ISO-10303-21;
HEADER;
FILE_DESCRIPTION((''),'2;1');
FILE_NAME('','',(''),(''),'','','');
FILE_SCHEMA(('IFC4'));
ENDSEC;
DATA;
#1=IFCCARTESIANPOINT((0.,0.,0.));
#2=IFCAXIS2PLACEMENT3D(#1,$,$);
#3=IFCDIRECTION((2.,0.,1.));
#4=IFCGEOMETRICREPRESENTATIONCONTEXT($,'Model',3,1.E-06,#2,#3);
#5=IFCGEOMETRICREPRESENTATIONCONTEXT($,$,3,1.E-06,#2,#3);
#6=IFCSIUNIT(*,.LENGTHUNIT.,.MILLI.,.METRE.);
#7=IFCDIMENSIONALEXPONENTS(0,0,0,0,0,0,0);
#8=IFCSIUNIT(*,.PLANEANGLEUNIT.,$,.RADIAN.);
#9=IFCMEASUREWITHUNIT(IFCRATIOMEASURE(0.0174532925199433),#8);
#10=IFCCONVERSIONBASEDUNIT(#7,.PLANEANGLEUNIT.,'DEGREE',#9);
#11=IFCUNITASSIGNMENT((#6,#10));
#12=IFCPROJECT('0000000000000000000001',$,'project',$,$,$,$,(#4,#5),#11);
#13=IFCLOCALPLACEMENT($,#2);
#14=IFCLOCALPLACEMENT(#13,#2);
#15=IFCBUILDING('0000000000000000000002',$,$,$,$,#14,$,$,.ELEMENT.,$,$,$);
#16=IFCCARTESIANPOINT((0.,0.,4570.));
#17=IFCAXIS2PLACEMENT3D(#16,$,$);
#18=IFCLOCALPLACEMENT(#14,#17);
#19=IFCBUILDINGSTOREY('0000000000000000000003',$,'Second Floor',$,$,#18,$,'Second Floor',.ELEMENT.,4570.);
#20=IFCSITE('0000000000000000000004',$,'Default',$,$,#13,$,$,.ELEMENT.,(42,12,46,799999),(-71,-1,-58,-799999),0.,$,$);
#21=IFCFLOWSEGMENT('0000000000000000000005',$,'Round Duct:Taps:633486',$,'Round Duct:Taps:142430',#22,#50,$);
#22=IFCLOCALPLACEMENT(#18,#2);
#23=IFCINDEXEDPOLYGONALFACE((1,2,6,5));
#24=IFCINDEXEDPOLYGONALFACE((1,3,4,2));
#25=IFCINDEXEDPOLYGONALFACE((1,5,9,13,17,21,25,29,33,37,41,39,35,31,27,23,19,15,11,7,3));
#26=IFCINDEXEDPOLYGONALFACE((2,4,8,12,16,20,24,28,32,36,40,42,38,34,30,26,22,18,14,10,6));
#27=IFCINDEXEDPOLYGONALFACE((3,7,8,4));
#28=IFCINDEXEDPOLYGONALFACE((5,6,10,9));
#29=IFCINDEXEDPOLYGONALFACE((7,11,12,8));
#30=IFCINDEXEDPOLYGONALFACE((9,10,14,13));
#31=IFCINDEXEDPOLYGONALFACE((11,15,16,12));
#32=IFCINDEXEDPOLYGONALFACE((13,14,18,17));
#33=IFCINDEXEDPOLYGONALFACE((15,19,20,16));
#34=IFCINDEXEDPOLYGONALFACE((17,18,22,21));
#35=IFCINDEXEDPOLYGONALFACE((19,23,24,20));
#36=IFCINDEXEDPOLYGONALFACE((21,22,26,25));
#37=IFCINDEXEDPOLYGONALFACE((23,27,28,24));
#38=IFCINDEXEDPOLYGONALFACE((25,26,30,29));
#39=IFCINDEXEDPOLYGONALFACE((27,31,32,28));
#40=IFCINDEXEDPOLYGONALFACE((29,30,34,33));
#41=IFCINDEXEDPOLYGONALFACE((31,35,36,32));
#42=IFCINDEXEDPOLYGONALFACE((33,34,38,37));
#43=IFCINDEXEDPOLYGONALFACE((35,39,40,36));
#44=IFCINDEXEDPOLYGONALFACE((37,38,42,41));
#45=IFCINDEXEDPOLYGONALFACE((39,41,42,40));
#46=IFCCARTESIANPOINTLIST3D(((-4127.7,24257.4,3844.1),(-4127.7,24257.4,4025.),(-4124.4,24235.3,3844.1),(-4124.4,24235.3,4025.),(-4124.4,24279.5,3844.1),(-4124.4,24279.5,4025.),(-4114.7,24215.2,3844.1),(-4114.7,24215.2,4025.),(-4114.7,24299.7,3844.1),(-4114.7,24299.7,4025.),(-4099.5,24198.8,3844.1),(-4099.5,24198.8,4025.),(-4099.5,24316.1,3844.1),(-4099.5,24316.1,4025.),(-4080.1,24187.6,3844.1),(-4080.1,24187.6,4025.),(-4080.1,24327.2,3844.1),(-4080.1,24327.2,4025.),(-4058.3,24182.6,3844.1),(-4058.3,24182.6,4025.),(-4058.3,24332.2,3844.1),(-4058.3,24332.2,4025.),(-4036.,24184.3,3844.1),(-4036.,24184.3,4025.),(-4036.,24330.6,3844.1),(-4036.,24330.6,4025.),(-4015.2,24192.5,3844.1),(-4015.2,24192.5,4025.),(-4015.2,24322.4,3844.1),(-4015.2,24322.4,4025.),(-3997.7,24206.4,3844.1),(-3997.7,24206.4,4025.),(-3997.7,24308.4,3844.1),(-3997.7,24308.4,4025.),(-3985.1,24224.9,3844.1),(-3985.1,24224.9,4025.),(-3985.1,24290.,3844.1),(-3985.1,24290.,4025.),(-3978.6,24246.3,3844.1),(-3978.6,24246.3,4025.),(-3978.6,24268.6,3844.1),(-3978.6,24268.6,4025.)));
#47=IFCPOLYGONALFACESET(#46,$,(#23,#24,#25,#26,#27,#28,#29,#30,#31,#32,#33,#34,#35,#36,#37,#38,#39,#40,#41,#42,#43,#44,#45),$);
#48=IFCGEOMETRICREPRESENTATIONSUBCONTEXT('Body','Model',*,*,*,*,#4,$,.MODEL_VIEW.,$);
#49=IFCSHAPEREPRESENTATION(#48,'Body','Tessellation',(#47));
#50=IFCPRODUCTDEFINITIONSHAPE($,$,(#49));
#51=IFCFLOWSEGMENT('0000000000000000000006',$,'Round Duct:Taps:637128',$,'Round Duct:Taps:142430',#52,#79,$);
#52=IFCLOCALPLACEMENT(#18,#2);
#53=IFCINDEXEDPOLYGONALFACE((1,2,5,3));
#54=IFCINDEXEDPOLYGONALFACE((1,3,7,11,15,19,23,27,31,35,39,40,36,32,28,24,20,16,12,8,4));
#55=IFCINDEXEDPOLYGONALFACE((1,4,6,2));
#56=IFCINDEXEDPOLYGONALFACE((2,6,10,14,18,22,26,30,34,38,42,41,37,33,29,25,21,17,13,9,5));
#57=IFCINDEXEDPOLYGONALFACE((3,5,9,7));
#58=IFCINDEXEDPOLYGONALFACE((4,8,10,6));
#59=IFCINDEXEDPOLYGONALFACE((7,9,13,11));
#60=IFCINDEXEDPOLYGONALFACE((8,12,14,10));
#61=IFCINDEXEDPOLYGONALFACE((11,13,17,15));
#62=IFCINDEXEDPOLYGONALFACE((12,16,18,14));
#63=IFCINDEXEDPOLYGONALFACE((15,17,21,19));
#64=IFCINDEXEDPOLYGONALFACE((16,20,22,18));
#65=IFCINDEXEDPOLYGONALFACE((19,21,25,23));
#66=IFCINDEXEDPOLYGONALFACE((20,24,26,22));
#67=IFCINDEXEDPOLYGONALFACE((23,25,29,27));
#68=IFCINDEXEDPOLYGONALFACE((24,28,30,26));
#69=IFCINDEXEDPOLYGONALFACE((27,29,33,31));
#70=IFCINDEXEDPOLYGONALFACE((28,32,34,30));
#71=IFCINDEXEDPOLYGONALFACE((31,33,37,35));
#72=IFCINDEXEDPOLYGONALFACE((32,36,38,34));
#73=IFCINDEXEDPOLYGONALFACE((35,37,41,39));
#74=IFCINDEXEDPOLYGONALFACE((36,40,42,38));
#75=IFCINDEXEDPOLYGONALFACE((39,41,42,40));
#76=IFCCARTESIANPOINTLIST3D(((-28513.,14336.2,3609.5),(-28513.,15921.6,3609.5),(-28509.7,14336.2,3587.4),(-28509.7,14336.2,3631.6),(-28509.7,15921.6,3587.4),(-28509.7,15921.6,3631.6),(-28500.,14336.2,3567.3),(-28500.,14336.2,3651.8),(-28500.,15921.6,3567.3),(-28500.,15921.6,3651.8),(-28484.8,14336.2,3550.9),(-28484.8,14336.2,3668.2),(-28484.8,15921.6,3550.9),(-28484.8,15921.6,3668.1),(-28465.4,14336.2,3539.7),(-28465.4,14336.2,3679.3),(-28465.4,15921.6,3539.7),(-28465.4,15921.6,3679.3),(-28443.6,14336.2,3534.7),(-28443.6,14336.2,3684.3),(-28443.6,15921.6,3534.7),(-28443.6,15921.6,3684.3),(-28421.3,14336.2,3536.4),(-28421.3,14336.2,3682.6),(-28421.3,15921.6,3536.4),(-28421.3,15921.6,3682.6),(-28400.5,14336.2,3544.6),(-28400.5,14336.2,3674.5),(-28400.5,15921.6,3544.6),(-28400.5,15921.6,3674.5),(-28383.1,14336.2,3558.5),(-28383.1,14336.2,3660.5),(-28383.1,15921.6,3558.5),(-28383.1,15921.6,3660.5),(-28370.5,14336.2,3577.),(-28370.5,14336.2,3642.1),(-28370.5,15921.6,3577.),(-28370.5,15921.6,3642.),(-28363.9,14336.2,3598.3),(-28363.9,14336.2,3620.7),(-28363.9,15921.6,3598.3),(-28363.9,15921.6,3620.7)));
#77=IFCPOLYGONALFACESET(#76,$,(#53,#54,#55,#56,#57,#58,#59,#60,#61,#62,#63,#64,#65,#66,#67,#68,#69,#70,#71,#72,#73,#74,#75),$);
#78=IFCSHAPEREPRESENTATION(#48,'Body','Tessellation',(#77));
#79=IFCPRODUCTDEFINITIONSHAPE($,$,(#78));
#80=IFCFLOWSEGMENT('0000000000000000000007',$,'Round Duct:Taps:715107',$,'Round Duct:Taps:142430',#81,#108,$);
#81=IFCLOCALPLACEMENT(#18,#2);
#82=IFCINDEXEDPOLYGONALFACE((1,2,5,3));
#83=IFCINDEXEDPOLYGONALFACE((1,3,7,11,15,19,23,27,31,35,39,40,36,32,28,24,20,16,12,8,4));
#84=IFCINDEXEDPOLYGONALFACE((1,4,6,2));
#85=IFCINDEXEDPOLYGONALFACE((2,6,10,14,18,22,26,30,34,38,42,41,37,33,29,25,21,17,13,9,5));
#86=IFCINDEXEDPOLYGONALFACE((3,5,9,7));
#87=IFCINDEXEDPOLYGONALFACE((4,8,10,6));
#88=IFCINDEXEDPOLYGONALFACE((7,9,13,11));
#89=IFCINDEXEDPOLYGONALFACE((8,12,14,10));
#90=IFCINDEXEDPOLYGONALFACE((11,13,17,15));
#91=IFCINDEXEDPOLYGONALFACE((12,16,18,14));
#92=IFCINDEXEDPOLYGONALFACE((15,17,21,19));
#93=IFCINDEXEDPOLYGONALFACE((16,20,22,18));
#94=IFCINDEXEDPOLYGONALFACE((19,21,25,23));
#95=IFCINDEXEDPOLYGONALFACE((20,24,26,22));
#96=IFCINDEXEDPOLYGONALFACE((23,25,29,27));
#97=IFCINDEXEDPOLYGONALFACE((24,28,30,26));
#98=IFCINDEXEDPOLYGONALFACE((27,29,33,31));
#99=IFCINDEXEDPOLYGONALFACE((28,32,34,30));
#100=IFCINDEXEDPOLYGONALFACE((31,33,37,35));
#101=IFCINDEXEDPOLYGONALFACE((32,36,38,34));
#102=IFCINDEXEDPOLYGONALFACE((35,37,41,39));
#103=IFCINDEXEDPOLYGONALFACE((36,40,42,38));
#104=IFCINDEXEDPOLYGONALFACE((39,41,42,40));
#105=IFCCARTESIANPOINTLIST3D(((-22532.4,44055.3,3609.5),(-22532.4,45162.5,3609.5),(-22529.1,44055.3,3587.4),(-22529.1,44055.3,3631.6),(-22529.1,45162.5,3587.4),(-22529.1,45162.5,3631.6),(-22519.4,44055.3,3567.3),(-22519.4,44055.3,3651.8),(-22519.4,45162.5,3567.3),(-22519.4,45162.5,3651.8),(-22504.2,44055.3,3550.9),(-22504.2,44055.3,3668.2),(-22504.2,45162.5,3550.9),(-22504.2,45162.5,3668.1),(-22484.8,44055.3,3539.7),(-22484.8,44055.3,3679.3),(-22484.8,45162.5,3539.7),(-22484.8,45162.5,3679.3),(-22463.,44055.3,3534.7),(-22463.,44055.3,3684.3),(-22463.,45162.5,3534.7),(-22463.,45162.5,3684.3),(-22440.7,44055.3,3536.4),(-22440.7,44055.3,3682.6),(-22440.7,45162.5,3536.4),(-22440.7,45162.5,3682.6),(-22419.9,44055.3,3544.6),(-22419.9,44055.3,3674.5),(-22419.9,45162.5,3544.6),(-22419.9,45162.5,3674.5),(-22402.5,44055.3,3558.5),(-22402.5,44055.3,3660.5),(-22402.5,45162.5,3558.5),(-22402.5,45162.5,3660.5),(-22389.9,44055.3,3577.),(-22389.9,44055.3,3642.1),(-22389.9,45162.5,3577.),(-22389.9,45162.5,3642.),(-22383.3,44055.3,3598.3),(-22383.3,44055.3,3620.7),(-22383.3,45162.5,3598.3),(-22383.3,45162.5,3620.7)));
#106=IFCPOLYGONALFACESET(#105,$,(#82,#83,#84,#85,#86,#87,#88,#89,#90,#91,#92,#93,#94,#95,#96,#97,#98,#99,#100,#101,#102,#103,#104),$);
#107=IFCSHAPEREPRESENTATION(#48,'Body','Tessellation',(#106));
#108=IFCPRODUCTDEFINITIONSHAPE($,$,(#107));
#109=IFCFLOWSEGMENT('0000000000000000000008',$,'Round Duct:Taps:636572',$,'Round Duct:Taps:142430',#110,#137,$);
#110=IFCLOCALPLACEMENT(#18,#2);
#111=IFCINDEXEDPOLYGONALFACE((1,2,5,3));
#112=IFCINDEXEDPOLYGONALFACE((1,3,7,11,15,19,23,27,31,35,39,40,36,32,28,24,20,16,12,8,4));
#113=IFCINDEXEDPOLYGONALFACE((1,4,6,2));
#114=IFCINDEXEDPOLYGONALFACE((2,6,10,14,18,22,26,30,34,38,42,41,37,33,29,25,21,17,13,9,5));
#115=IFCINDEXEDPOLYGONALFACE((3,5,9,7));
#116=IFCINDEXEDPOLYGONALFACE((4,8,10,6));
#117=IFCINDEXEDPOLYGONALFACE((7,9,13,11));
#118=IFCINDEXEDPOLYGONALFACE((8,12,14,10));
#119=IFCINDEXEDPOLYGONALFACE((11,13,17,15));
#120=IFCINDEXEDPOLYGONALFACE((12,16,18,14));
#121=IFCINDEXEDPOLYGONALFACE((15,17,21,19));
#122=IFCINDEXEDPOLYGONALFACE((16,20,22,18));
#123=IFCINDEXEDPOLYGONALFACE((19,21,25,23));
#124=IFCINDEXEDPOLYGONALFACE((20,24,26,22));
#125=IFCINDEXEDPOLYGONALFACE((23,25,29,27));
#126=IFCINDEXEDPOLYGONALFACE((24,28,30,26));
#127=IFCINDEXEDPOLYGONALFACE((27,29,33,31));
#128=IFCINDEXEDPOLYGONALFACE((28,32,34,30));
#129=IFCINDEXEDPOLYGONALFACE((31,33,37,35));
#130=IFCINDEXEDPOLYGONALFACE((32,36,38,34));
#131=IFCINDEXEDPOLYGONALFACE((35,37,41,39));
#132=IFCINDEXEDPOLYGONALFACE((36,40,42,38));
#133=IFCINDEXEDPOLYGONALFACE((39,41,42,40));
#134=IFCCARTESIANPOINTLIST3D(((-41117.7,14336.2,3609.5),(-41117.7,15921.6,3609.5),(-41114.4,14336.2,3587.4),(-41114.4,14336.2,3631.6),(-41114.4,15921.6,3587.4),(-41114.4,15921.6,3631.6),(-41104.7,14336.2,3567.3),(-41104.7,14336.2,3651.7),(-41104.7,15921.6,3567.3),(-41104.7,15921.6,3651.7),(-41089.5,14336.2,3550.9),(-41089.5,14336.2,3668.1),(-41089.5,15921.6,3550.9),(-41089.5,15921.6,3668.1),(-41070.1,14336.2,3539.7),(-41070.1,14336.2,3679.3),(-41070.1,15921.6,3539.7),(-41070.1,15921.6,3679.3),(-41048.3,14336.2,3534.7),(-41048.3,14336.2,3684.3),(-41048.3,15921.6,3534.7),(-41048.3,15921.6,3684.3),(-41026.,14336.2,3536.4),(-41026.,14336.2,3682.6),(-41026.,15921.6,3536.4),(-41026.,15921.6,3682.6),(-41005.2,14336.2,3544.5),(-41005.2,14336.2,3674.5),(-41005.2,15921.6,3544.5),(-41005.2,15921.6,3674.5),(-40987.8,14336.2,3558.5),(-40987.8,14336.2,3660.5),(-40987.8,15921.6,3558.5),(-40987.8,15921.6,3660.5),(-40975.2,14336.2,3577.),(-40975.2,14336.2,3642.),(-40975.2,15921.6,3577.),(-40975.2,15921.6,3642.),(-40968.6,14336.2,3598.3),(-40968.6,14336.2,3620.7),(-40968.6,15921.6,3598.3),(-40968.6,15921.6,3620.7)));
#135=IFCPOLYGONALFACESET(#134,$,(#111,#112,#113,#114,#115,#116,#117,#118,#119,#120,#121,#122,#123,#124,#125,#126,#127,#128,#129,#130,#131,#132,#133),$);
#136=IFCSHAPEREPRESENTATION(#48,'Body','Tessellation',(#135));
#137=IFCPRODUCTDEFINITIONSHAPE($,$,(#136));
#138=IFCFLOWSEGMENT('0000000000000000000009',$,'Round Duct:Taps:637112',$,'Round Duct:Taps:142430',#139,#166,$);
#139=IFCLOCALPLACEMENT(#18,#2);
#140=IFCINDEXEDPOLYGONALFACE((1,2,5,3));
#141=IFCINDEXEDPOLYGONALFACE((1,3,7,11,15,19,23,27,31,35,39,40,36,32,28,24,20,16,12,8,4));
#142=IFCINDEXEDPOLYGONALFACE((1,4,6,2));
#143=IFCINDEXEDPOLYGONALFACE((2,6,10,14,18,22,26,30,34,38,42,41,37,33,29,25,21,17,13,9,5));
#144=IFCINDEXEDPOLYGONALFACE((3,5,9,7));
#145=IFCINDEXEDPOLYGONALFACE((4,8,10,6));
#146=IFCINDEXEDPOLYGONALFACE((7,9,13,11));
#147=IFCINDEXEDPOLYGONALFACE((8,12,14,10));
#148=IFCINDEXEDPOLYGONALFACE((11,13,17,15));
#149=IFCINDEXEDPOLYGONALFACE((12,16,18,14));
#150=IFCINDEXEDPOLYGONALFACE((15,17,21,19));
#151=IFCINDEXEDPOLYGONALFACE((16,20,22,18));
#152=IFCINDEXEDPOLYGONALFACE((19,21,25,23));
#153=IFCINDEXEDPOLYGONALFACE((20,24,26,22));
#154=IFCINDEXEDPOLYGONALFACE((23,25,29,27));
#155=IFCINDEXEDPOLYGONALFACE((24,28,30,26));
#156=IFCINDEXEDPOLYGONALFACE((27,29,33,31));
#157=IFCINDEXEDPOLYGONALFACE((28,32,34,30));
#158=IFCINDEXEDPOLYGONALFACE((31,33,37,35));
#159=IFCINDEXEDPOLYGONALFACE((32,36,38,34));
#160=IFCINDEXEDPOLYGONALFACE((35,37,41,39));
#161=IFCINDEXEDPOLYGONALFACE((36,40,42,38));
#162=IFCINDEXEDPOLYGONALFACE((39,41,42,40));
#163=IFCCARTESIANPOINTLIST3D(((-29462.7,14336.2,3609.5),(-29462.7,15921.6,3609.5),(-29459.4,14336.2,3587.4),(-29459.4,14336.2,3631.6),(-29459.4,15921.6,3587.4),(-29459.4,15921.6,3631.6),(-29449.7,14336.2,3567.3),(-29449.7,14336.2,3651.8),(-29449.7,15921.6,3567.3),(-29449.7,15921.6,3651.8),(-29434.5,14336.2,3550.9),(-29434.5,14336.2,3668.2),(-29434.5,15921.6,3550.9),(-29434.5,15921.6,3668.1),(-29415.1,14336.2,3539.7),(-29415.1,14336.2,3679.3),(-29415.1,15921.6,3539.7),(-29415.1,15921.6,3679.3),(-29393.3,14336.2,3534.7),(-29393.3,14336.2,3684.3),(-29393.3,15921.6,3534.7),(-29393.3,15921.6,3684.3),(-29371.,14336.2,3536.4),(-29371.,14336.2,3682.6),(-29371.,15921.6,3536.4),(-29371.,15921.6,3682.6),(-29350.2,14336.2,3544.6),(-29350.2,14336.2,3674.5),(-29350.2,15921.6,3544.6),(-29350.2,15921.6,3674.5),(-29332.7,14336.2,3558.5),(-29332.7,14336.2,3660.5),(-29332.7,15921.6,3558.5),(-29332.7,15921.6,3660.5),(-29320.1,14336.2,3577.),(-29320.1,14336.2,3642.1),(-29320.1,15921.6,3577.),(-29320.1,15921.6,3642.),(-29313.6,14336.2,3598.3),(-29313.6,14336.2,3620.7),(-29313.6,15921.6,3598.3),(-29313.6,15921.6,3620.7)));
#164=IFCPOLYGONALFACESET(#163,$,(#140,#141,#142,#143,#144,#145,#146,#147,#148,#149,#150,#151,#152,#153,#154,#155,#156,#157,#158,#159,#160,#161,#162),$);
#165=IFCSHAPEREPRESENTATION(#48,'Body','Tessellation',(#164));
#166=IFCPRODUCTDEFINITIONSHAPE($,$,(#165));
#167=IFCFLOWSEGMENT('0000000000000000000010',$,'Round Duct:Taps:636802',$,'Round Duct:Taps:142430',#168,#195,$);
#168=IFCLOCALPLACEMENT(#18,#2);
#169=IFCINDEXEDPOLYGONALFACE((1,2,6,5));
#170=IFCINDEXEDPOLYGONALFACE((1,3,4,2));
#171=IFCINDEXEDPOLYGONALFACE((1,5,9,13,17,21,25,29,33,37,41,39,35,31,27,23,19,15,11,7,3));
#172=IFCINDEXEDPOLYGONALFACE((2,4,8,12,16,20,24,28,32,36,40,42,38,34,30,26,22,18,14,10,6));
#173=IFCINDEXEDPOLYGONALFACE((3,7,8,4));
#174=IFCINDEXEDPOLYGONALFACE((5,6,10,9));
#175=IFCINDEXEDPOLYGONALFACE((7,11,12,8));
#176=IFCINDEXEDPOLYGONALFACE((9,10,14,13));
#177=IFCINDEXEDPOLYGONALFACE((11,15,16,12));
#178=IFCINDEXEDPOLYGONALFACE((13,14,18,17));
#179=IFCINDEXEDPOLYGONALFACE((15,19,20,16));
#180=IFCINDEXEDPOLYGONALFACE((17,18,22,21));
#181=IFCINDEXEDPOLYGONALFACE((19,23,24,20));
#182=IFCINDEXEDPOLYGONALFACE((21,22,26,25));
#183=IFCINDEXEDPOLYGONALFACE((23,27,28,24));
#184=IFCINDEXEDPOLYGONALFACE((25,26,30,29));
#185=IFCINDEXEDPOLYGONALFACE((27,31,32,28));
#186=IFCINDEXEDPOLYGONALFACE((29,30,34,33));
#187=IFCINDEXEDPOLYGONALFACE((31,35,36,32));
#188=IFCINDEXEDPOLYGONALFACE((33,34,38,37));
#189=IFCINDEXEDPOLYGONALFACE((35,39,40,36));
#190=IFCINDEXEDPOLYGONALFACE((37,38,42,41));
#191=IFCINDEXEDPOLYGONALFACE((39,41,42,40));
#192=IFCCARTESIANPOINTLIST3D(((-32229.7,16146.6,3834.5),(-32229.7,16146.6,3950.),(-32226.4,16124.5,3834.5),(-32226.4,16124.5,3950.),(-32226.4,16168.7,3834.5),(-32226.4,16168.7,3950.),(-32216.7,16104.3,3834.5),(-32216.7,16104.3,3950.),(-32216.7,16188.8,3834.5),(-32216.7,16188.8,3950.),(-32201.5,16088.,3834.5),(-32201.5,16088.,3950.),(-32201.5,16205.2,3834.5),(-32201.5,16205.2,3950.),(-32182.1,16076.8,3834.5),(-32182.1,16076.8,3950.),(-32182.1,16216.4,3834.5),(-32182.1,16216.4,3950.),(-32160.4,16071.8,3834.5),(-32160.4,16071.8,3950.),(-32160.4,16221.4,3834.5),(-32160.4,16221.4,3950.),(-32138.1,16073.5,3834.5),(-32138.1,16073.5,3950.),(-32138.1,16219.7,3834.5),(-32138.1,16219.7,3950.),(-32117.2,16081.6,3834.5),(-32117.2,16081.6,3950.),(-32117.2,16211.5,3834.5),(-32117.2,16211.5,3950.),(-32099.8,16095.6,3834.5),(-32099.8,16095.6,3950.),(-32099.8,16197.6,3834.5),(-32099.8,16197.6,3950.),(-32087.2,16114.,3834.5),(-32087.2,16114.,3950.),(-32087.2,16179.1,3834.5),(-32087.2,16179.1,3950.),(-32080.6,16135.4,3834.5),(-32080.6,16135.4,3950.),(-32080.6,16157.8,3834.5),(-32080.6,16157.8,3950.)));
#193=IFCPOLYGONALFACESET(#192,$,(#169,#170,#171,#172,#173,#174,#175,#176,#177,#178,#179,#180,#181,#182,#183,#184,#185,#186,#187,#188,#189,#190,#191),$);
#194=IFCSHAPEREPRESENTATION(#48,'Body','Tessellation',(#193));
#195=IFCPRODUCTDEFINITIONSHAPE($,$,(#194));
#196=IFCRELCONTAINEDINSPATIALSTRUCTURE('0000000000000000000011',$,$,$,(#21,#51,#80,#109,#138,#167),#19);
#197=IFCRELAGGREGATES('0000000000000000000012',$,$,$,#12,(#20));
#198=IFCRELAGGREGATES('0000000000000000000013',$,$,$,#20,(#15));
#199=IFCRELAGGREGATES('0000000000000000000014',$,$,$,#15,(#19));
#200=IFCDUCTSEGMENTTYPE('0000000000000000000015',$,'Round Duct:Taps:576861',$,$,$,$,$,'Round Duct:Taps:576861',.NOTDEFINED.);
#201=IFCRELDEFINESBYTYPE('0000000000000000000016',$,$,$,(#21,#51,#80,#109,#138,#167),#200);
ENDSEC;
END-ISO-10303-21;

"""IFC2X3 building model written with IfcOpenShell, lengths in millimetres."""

from ifc_helpers import new_model, entity, si_unit, converted_unit, direction, frame, frame_2d, origin, origin_2d_with_axis, place, context, subcontext, project, spatial, circle, extrude, type_object, element, save


model = new_model("IFC2X3")

# Units and contexts
model_context = context("Model", 3, precision=1e-06, world=origin(), true_north=direction((2.0, 0.0, 1.0)))
context_of_model = context(None, 3, precision=1e-06, world=origin(), true_north=direction((2.0, 0.0, 1.0)))
body_context = subcontext(model_context, "Body", "Model", "MODEL_VIEW")
ifc_project = project(units=[si_unit("LENGTHUNIT", "METRE", prefix="MILLI"), converted_unit("PLANEANGLEUNIT", "DEGREE", entity("IfcRatioMeasure", 0.0174532925199433), si_unit("PLANEANGLEUNIT", "RADIAN"), dimensions=[0, 0, 0, 0, 0, 0, 0])], contexts=[model_context, context_of_model])

# Site, building, storey
site_placement = place(None, origin())
site = spatial("IfcSite", under=ifc_project, at=site_placement, Name="Default", CompositionType="ELEMENT", RefLatitude=(42, 12, 46, 799999), RefLongitude=(-71, -1, -58, -799999), RefElevation=0.0)
building_placement = place(site_placement, origin())
building = spatial("IfcBuilding", under=site, at=building_placement, CompositionType="ELEMENT")
storey_placement = place(building_placement, frame((0.0, 0.0, 4570.0)))
storey = spatial("IfcBuildingStorey", under=building, at=storey_placement, Name="Second Floor", LongName="Second Floor", CompositionType="ELEMENT", Elevation=4570.0)

# Flow segments
duct_segment_type_1 = type_object("IfcDuctSegmentType", Name="Round Duct:Taps:576861", ElementType="Round Duct:Taps:576861", PredefinedType="NOTDEFINED")
flow_segment_1_placement = place(storey_placement, origin())
element("IfcFlowSegment", 1, at=flow_segment_1_placement, inside=storey, type_object=duct_segment_type_1, Name="Round Duct:Taps:633486", ObjectType="Round Duct:Taps:142430", context=body_context, shape_type="SweptSolid", body=[
    extrude(circle(Radius=75.0, at=frame_2d((0.0, 0.0), x_axis=(1.0, 0.0))), frame((-4052.7, 24257.4, 3844.1), z_axis=(0.0, 0.0, 1.0), x_axis=(-1.0, 0.0, 0.0)), (0.0, 0.0, 1.0), 180.9),
])
flow_segment_2_placement = place(storey_placement, origin())
element("IfcFlowSegment", 2, at=flow_segment_2_placement, inside=storey, type_object=duct_segment_type_1, Name="Round Duct:Taps:637128", ObjectType="Round Duct:Taps:142430", context=body_context, shape_type="SweptSolid", body=[
    extrude(circle(Radius=75.0, at=frame_2d((0.0, 0.0), x_axis=(1.0, 0.0))), frame((-28438.0, 14336.2, 3609.5), z_axis=(0.0, 1.0, -0.000014), x_axis=(-1.0, 0.0, 0.0)), (0.0, 0.0, 1.0), 1585.4),
])
flow_segment_3_placement = place(storey_placement, origin())
element("IfcFlowSegment", 3, at=flow_segment_3_placement, inside=storey, type_object=duct_segment_type_1, Name="Round Duct:Taps:715107", ObjectType="Round Duct:Taps:142430", context=body_context, shape_type="SweptSolid", body=[
    extrude(circle(Radius=75.0, at=origin_2d_with_axis()), frame((-22457.4, 45162.5, 3609.5), z_axis=(0.0, -1.0, 0.000021), x_axis=(-1.0, 0.0, 0.0)), (0.0, 0.0, 1.0), 1107.2),
])
flow_segment_4_placement = place(storey_placement, origin())
element("IfcFlowSegment", 4, at=flow_segment_4_placement, inside=storey, type_object=duct_segment_type_1, Name="Round Duct:Taps:636572", ObjectType="Round Duct:Taps:142430", context=body_context, shape_type="SweptSolid", body=[
    extrude(circle(Radius=75.0, at=frame_2d((0.0, 0.0), x_axis=(1.0, 0.0))), frame((-41042.7, 14336.2, 3609.5), z_axis=(0.0, 1.0, 0.0), x_axis=(-1.0, 0.0, 0.0)), (0.0, 0.0, 1.0), 1585.4),
])
flow_segment_5_placement = place(storey_placement, origin())
element("IfcFlowSegment", 5, at=flow_segment_5_placement, inside=storey, type_object=duct_segment_type_1, Name="Round Duct:Taps:637112", ObjectType="Round Duct:Taps:142430", context=body_context, shape_type="SweptSolid", body=[
    extrude(circle(Radius=75.0, at=frame_2d((0.0, 0.0), x_axis=(1.0, 0.0))), frame((-29387.7, 14336.2, 3609.5), z_axis=(0.0, 1.0, -0.000014), x_axis=(-1.0, 0.0, 0.0)), (0.0, 0.0, 1.0), 1585.4),
])
flow_segment_6_placement = place(storey_placement, origin())
element("IfcFlowSegment", 6, at=flow_segment_6_placement, inside=storey, type_object=duct_segment_type_1, Name="Round Duct:Taps:636802", ObjectType="Round Duct:Taps:142430", context=body_context, shape_type="SweptSolid", body=[
    extrude(circle(Radius=75.0, at=frame_2d((0.0, 0.0), x_axis=(1.0, 0.0))), frame((-32154.7, 16146.6, 3834.5), z_axis=(0.0, 0.0, 1.0), x_axis=(-1.0, 0.0, 0.0)), (0.0, 0.0, 1.0), 115.5),
])

save(model, "model.ifc")
